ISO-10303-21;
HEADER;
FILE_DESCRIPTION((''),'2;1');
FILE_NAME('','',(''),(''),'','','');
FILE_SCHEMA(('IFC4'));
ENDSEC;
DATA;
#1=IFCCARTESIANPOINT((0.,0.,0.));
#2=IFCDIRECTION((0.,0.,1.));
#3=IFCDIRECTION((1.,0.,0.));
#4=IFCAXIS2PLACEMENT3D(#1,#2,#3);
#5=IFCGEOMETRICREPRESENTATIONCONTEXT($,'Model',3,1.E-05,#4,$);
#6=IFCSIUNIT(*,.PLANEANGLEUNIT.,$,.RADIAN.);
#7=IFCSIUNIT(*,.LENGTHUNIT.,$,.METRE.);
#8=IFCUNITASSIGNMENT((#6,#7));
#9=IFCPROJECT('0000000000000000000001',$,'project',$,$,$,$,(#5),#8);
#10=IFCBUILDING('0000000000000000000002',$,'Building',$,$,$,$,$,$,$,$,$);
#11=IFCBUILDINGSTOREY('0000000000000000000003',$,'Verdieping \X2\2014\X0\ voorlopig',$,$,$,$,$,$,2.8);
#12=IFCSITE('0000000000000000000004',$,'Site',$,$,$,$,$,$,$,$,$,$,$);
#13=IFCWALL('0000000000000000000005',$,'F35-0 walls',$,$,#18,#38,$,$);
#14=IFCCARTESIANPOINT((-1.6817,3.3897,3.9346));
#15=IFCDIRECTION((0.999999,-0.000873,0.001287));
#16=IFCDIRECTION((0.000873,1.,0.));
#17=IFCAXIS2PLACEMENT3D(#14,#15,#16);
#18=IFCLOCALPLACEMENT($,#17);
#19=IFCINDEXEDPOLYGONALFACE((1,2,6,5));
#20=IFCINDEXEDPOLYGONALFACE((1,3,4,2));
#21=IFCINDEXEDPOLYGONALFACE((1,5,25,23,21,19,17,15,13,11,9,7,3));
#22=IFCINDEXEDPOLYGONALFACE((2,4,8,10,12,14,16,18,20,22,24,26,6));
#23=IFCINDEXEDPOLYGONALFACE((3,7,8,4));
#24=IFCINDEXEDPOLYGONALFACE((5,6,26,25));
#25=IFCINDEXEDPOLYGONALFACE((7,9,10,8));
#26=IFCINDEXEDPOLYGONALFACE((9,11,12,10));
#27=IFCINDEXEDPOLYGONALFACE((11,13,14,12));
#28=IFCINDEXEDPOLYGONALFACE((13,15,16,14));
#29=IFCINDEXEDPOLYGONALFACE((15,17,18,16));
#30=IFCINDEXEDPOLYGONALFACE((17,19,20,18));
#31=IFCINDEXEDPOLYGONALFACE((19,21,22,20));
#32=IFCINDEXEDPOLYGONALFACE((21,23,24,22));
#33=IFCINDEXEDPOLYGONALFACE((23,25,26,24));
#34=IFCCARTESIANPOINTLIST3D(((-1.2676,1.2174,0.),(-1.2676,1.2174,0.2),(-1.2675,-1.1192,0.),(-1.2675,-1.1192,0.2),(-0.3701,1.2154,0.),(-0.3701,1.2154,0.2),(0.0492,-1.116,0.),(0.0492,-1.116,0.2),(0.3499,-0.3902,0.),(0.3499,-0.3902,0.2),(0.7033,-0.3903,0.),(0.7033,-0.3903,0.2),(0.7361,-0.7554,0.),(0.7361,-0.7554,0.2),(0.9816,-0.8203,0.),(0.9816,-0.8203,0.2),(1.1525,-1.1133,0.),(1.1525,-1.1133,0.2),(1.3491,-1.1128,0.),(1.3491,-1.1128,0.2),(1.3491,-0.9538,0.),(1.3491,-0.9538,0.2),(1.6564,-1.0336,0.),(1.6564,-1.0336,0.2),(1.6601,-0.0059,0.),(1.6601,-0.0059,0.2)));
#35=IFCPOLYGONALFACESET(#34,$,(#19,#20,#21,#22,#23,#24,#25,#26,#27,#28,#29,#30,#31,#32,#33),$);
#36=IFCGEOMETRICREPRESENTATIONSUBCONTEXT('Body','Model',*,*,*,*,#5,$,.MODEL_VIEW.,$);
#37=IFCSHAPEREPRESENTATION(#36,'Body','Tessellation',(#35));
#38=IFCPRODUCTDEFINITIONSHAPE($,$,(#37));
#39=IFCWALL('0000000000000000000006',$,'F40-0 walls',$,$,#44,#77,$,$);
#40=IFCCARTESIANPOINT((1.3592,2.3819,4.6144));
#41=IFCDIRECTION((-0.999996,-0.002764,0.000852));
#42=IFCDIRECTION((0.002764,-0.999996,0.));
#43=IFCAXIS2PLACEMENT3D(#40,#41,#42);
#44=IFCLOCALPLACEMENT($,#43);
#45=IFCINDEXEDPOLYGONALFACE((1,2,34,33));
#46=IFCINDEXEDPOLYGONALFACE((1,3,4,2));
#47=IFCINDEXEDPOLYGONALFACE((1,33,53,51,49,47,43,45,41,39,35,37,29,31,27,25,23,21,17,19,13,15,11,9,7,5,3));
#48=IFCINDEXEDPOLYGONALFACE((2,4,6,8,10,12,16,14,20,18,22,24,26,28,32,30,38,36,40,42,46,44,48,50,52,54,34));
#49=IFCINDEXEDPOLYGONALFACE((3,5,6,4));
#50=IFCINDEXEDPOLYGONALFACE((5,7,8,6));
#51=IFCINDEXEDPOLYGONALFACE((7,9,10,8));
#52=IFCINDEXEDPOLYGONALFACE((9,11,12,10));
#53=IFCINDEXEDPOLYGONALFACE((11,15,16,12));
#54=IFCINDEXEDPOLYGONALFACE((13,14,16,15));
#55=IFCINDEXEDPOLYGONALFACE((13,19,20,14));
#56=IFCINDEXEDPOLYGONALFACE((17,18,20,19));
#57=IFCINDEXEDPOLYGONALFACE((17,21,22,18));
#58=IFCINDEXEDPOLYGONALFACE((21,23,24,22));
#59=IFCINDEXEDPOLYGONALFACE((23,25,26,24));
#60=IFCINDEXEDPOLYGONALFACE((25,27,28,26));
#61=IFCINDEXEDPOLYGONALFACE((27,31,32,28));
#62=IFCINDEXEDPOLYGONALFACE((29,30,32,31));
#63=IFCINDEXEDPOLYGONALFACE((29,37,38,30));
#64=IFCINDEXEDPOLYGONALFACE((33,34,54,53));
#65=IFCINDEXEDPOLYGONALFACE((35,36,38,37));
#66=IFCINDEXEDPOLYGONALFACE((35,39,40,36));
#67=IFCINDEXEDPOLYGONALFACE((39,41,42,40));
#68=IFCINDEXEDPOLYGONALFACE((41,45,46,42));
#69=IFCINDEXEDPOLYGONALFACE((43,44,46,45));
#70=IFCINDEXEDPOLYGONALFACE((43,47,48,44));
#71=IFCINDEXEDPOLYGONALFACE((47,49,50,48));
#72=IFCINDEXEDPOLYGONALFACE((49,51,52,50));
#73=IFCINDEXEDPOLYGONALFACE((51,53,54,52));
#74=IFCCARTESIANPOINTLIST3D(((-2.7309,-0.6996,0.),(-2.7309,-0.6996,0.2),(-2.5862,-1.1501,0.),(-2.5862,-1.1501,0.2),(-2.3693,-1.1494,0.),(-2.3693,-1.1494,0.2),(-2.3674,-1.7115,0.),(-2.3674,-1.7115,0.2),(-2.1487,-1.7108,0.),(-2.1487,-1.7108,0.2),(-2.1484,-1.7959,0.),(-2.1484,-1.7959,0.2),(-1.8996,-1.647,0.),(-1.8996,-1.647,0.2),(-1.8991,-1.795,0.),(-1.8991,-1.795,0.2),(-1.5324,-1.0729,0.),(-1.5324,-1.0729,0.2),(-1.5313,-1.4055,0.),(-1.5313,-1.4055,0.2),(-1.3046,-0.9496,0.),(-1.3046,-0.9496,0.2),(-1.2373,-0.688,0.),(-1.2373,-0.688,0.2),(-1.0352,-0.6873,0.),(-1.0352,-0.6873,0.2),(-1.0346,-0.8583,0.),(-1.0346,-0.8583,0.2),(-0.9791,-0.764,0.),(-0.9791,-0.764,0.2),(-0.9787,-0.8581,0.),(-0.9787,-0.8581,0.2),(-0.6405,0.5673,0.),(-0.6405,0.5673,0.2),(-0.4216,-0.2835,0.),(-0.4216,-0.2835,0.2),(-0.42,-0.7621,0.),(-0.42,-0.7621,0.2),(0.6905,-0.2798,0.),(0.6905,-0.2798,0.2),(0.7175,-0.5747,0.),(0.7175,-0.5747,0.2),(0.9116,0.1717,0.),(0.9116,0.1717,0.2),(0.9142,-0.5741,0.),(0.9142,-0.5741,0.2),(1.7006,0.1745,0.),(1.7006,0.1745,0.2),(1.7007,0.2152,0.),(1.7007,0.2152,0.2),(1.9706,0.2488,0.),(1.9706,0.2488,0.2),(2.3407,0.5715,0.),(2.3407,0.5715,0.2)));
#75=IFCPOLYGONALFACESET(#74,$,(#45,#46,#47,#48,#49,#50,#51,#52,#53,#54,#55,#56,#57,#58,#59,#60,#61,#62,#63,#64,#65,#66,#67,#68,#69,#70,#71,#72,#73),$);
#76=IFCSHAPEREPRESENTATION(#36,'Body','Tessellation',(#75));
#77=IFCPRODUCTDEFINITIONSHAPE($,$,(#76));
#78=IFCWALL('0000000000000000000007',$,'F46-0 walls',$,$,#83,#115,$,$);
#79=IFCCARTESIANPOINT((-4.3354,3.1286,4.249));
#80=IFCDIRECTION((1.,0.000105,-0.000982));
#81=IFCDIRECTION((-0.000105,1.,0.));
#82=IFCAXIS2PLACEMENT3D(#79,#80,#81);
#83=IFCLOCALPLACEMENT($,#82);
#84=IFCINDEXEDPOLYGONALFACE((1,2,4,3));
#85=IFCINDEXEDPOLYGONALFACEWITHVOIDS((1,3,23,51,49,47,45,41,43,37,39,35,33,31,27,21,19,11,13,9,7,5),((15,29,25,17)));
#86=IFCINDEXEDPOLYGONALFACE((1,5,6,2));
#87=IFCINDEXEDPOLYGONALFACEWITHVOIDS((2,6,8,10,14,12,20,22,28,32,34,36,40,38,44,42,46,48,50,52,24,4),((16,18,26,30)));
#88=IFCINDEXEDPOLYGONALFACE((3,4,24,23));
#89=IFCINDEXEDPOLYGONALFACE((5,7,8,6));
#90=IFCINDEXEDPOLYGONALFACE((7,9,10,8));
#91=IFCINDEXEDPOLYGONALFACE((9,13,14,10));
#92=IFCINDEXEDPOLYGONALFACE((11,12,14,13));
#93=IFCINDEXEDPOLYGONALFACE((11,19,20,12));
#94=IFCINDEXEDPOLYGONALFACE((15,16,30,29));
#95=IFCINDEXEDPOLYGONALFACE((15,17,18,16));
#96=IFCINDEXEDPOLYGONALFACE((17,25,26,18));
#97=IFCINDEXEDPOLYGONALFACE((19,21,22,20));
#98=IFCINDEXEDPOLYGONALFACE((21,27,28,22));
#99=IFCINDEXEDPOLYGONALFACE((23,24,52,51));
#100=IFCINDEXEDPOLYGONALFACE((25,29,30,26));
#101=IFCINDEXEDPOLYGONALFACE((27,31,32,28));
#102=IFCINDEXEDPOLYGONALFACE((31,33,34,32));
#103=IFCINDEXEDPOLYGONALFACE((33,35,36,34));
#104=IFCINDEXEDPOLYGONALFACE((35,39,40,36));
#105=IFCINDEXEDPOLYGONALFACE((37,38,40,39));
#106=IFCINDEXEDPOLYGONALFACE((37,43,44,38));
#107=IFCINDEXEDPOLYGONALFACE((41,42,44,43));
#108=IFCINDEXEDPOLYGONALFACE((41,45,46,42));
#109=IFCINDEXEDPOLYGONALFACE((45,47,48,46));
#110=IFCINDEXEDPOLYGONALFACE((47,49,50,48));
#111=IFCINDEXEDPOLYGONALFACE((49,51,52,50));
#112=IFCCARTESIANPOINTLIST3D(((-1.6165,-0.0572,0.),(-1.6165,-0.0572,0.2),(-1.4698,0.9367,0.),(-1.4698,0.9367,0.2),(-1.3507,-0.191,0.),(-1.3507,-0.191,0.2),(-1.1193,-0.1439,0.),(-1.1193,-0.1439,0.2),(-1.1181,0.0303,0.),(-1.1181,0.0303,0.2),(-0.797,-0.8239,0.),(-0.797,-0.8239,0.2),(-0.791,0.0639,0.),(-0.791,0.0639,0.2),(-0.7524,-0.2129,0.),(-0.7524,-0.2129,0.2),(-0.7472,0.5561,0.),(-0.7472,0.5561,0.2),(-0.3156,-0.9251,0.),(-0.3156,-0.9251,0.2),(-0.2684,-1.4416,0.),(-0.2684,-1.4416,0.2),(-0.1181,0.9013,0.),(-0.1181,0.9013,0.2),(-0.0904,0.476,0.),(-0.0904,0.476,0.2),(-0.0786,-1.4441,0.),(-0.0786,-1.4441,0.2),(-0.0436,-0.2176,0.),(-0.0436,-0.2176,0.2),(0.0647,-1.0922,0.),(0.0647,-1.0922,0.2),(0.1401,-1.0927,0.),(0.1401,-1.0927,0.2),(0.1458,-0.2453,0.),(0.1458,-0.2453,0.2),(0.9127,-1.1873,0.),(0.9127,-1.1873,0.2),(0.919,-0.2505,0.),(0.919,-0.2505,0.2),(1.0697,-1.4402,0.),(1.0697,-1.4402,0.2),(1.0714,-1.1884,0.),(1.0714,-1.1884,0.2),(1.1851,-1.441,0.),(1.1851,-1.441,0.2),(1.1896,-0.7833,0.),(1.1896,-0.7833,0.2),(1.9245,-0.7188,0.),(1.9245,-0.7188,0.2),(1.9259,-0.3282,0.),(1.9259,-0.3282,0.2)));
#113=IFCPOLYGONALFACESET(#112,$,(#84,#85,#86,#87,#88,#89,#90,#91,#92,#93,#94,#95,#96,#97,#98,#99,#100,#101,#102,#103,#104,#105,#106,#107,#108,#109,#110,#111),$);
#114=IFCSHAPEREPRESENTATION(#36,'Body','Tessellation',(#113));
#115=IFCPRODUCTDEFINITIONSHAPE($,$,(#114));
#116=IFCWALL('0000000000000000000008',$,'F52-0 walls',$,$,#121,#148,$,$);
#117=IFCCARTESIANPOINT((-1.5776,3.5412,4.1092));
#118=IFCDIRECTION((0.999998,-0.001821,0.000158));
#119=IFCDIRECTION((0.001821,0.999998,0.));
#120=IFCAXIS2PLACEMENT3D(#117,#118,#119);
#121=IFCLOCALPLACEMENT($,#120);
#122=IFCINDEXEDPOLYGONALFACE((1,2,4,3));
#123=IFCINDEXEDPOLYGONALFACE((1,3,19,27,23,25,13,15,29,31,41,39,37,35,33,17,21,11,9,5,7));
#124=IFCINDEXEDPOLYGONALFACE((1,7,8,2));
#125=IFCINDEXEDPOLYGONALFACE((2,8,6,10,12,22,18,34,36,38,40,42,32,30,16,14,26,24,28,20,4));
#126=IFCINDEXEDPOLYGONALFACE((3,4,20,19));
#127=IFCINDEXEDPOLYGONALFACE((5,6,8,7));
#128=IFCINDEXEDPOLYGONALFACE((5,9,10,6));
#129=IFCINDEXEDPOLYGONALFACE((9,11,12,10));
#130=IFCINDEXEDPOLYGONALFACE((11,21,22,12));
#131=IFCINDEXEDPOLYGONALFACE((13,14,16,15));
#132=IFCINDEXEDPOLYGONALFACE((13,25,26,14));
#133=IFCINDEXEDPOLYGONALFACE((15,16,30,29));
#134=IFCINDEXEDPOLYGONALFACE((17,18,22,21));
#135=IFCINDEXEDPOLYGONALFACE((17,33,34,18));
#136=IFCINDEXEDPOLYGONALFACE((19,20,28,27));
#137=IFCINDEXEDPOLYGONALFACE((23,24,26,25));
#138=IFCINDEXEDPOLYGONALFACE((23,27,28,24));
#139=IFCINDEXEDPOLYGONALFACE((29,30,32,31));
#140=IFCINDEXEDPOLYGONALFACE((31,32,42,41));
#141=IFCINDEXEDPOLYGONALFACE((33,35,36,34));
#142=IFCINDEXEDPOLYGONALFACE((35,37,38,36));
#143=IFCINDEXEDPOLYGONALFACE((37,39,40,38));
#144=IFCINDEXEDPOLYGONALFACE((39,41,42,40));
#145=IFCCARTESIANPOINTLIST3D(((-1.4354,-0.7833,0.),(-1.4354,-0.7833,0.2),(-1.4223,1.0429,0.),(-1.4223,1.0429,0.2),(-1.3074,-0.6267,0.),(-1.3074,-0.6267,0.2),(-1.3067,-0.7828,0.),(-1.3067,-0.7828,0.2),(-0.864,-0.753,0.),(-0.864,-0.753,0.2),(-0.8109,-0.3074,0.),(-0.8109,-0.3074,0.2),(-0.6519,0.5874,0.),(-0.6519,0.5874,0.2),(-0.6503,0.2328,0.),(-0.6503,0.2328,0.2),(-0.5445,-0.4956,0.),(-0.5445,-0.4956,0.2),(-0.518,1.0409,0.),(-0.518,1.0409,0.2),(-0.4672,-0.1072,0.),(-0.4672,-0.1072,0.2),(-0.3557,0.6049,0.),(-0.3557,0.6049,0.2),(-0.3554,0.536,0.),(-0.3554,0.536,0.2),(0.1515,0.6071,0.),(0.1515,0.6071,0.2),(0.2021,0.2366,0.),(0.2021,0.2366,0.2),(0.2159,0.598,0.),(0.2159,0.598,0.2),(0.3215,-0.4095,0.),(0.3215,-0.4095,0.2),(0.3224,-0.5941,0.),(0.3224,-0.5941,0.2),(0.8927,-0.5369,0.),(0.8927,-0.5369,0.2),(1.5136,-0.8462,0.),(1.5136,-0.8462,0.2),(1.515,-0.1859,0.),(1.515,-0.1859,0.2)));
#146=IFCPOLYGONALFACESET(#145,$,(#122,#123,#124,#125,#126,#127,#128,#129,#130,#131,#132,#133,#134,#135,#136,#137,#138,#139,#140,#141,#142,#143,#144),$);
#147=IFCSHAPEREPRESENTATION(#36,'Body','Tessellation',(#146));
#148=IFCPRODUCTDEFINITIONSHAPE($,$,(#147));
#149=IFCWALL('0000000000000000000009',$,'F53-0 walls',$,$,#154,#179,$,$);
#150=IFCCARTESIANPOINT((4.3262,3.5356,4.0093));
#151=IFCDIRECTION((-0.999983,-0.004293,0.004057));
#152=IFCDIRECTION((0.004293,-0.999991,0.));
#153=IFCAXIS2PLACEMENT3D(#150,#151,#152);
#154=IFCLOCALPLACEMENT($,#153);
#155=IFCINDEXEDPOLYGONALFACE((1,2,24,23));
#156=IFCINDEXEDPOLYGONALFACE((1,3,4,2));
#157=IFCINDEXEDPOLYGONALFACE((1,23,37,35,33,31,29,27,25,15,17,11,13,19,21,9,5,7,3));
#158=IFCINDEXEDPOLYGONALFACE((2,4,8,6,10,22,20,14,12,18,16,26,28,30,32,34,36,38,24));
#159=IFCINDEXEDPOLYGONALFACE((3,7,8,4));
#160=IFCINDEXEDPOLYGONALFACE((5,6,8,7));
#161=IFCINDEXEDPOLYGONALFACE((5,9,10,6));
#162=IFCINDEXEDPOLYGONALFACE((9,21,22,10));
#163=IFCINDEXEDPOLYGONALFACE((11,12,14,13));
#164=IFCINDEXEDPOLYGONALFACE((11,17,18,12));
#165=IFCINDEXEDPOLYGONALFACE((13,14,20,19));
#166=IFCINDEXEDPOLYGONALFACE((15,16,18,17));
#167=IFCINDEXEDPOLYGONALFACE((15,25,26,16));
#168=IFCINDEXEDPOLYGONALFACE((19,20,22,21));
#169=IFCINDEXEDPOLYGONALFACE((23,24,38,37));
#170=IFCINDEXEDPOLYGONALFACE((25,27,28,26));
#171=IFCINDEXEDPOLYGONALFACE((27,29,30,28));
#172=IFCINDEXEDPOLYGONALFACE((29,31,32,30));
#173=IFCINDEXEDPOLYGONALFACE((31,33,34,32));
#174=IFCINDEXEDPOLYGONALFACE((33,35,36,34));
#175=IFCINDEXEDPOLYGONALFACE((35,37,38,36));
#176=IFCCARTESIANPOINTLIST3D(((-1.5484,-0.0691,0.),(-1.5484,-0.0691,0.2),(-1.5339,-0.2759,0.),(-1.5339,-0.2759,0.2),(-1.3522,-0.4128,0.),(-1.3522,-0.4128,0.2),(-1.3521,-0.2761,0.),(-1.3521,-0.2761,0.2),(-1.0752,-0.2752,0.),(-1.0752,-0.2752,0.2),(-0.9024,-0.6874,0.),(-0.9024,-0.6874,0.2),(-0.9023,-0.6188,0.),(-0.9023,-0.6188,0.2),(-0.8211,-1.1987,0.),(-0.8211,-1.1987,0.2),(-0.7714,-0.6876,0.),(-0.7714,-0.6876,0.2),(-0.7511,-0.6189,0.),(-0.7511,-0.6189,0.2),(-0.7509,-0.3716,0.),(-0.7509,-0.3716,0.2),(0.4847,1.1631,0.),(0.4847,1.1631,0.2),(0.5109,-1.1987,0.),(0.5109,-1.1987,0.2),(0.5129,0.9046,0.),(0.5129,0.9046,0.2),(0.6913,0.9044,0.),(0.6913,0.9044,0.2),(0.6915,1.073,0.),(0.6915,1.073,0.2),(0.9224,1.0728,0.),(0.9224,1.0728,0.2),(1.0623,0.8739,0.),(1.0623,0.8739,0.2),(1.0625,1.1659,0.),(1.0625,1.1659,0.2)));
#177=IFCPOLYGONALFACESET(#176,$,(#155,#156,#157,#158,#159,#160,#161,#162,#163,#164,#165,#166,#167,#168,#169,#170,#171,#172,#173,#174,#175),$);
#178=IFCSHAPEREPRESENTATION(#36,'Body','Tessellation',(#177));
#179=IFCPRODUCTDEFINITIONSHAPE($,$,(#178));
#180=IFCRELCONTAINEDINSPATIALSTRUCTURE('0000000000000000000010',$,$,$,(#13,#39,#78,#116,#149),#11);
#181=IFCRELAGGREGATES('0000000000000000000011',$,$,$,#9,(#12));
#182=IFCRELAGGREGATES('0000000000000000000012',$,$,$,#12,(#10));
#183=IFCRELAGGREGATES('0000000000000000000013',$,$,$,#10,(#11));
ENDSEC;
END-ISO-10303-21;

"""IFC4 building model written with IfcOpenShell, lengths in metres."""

from ifc_helpers import new_model, si_unit, frame, origin_with_axes, place, context, subcontext, project, spatial, polyline, outline, extrude, element, save


model = new_model("IFC4")

# Units and contexts
model_context = context("Model", 3, precision=1e-05, world=origin_with_axes())
body_context = subcontext(model_context, "Body", "Model", "MODEL_VIEW")
ifc_project = project(units=[si_unit("PLANEANGLEUNIT", "RADIAN"), si_unit("LENGTHUNIT", "METRE")], contexts=[model_context])

# Site, building, storey
site = spatial("IfcSite", under=ifc_project, Name="Site")
building = spatial("IfcBuilding", under=site, Name="Building")
storey = spatial("IfcBuildingStorey", under=building, Name="Verdieping — voorlopig", Elevation=2.8)

# Walls
wall_1_placement = place(None, frame((-1.6817, 3.3897, 3.9346), z_axis=(0.999999, -0.000873, 0.001287), x_axis=(0.000873, 1.0, 0.0)))
element("IfcWall", 1, at=wall_1_placement, inside=storey, Name="F35-0 walls", context=body_context, shape_type="SweptSolid", body=[
    extrude(outline(polyline([(1.3491, -1.1128), (1.3491, -0.9538), (1.6564, -1.0336), (1.6601, -0.0059), (-0.3701, 1.2154), (-1.2676, 1.2174), (-1.2675, -1.1192), (0.0492, -1.116), (0.3499, -0.3902), (0.7033, -0.3903), (0.7361, -0.7554), (0.9816, -0.8203), (1.1525, -1.1133), (1.3491, -1.1128)])), origin_with_axes(), (0.0, 0.0, 1.0), 0.2),
])
wall_2_placement = place(None, frame((1.3592, 2.3819, 4.6144), z_axis=(-0.999996, -0.002764, 0.000852), x_axis=(0.002764, -0.999996, 0.0)))
element("IfcWall", 2, at=wall_2_placement, inside=storey, Name="F40-0 walls", context=body_context, shape_type="SweptSolid", body=[
    extrude(outline(polyline([(-2.1484, -1.7959), (-1.8991, -1.795), (-1.8996, -1.647), (-1.5313, -1.4055), (-1.5324, -1.0729), (-1.3046, -0.9496), (-1.2373, -0.688), (-1.0352, -0.6873), (-1.0346, -0.8583), (-0.9787, -0.8581), (-0.9791, -0.764), (-0.42, -0.7621), (-0.4216, -0.2835), (0.6905, -0.2798), (0.7175, -0.5747), (0.9142, -0.5741), (0.9116, 0.1717), (1.7006, 0.1745), (1.7007, 0.2152), (1.9706, 0.2488), (2.3407, 0.5715), (-0.6405, 0.5673), (-2.7309, -0.6996), (-2.5862, -1.1501), (-2.3693, -1.1494), (-2.3674, -1.7115), (-2.1487, -1.7108), (-2.1484, -1.7959)])), origin_with_axes(), (0.0, 0.0, 1.0), 0.2),
])

# Wall, opening
wall_3_placement = place(None, frame((-4.3354, 3.1286, 4.249), z_axis=(1.0, 0.000105, -0.000982), x_axis=(-0.000105, 1.0, 0.0)))
wall_3 = element("IfcWall", 3, at=wall_3_placement, inside=storey, Name="F46-0 walls", context=body_context, shape_type="SweptSolid", body=[
    extrude(outline(polyline([(-0.2684, -1.4416), (-0.0786, -1.4441), (0.0647, -1.0922), (0.1401, -1.0927), (0.1458, -0.2453), (0.919, -0.2505), (0.9127, -1.1873), (1.0714, -1.1884), (1.0697, -1.4402), (1.1851, -1.441), (1.1896, -0.7833), (1.9245, -0.7188), (1.9259, -0.3282), (-0.1181, 0.9013), (-1.4698, 0.9367), (-1.6165, -0.0572), (-1.3507, -0.191), (-1.1193, -0.1439), (-1.1181, 0.0303), (-0.791, 0.0639), (-0.797, -0.8239), (-0.3156, -0.9251), (-0.2684, -1.4416)])), origin_with_axes(), (0.0, 0.0, 1.0), 0.2),
])
opening_1_placement = place(wall_3_placement, frame((0.0, 0.0, -0.05), z_axis=(0.0, 0.0, 1.0), x_axis=(1.0, 0.0, 0.0)))
element("IfcOpeningElement", 4, at=opening_1_placement, cuts=wall_3, PredefinedType="OPENING", context=body_context, shape_type="SweptSolid", body=[
    extrude(outline(polyline([(-0.7524, -0.2129), (-0.7472, 0.5561), (-0.0904, 0.476), (-0.0436, -0.2176), (-0.7524, -0.2129)])), origin_with_axes(), (0.0, 0.0, 1.0), 0.3),
])

# Walls
wall_4_placement = place(None, frame((-1.5776, 3.5412, 4.1092), z_axis=(0.999998, -0.001821, 0.000158), x_axis=(0.001821, 0.999998, 0.0)))
element("IfcWall", 5, at=wall_4_placement, inside=storey, Name="F52-0 walls", context=body_context, shape_type="SweptSolid", body=[
    extrude(outline(polyline([(-1.4354, -0.7833), (-1.3067, -0.7828), (-1.3074, -0.6267), (-0.864, -0.753), (-0.8109, -0.3074), (-0.4672, -0.1072), (-0.5445, -0.4956), (0.3215, -0.4095), (0.3224, -0.5941), (0.8927, -0.5369), (1.5136, -0.8462), (1.515, -0.1859), (0.2159, 0.598), (0.2021, 0.2366), (-0.6503, 0.2328), (-0.6519, 0.5874), (-0.3554, 0.536), (-0.3557, 0.6049), (0.1515, 0.6071), (-0.518, 1.0409), (-1.4223, 1.0429), (-1.4354, -0.7833)])), origin_with_axes(), (0.0, 0.0, 1.0), 0.2),
])
wall_5_placement = place(None, frame((4.3262, 3.5356, 4.0093), z_axis=(-0.999983, -0.004293, 0.004057), x_axis=(0.004293, -0.999991, 0.0)))
element("IfcWall", 6, at=wall_5_placement, inside=storey, Name="F53-0 walls", context=body_context, shape_type="SweptSolid", body=[
    extrude(outline(polyline([(-0.8211, -1.1987), (0.5109, -1.1987), (0.5129, 0.9046), (0.6913, 0.9044), (0.6915, 1.073), (0.9224, 1.0728), (1.0623, 0.8739), (1.0625, 1.1659), (0.4847, 1.1631), (-1.5484, -0.0691), (-1.5339, -0.2759), (-1.3521, -0.2761), (-1.3522, -0.4128), (-1.0752, -0.2752), (-0.7509, -0.3716), (-0.7511, -0.6189), (-0.9023, -0.6188), (-0.9024, -0.6874), (-0.7714, -0.6876), (-0.8211, -1.1987)])), origin_with_axes(), (0.0, 0.0, 1.0), 0.2),
])

save(model, "model.ifc")
